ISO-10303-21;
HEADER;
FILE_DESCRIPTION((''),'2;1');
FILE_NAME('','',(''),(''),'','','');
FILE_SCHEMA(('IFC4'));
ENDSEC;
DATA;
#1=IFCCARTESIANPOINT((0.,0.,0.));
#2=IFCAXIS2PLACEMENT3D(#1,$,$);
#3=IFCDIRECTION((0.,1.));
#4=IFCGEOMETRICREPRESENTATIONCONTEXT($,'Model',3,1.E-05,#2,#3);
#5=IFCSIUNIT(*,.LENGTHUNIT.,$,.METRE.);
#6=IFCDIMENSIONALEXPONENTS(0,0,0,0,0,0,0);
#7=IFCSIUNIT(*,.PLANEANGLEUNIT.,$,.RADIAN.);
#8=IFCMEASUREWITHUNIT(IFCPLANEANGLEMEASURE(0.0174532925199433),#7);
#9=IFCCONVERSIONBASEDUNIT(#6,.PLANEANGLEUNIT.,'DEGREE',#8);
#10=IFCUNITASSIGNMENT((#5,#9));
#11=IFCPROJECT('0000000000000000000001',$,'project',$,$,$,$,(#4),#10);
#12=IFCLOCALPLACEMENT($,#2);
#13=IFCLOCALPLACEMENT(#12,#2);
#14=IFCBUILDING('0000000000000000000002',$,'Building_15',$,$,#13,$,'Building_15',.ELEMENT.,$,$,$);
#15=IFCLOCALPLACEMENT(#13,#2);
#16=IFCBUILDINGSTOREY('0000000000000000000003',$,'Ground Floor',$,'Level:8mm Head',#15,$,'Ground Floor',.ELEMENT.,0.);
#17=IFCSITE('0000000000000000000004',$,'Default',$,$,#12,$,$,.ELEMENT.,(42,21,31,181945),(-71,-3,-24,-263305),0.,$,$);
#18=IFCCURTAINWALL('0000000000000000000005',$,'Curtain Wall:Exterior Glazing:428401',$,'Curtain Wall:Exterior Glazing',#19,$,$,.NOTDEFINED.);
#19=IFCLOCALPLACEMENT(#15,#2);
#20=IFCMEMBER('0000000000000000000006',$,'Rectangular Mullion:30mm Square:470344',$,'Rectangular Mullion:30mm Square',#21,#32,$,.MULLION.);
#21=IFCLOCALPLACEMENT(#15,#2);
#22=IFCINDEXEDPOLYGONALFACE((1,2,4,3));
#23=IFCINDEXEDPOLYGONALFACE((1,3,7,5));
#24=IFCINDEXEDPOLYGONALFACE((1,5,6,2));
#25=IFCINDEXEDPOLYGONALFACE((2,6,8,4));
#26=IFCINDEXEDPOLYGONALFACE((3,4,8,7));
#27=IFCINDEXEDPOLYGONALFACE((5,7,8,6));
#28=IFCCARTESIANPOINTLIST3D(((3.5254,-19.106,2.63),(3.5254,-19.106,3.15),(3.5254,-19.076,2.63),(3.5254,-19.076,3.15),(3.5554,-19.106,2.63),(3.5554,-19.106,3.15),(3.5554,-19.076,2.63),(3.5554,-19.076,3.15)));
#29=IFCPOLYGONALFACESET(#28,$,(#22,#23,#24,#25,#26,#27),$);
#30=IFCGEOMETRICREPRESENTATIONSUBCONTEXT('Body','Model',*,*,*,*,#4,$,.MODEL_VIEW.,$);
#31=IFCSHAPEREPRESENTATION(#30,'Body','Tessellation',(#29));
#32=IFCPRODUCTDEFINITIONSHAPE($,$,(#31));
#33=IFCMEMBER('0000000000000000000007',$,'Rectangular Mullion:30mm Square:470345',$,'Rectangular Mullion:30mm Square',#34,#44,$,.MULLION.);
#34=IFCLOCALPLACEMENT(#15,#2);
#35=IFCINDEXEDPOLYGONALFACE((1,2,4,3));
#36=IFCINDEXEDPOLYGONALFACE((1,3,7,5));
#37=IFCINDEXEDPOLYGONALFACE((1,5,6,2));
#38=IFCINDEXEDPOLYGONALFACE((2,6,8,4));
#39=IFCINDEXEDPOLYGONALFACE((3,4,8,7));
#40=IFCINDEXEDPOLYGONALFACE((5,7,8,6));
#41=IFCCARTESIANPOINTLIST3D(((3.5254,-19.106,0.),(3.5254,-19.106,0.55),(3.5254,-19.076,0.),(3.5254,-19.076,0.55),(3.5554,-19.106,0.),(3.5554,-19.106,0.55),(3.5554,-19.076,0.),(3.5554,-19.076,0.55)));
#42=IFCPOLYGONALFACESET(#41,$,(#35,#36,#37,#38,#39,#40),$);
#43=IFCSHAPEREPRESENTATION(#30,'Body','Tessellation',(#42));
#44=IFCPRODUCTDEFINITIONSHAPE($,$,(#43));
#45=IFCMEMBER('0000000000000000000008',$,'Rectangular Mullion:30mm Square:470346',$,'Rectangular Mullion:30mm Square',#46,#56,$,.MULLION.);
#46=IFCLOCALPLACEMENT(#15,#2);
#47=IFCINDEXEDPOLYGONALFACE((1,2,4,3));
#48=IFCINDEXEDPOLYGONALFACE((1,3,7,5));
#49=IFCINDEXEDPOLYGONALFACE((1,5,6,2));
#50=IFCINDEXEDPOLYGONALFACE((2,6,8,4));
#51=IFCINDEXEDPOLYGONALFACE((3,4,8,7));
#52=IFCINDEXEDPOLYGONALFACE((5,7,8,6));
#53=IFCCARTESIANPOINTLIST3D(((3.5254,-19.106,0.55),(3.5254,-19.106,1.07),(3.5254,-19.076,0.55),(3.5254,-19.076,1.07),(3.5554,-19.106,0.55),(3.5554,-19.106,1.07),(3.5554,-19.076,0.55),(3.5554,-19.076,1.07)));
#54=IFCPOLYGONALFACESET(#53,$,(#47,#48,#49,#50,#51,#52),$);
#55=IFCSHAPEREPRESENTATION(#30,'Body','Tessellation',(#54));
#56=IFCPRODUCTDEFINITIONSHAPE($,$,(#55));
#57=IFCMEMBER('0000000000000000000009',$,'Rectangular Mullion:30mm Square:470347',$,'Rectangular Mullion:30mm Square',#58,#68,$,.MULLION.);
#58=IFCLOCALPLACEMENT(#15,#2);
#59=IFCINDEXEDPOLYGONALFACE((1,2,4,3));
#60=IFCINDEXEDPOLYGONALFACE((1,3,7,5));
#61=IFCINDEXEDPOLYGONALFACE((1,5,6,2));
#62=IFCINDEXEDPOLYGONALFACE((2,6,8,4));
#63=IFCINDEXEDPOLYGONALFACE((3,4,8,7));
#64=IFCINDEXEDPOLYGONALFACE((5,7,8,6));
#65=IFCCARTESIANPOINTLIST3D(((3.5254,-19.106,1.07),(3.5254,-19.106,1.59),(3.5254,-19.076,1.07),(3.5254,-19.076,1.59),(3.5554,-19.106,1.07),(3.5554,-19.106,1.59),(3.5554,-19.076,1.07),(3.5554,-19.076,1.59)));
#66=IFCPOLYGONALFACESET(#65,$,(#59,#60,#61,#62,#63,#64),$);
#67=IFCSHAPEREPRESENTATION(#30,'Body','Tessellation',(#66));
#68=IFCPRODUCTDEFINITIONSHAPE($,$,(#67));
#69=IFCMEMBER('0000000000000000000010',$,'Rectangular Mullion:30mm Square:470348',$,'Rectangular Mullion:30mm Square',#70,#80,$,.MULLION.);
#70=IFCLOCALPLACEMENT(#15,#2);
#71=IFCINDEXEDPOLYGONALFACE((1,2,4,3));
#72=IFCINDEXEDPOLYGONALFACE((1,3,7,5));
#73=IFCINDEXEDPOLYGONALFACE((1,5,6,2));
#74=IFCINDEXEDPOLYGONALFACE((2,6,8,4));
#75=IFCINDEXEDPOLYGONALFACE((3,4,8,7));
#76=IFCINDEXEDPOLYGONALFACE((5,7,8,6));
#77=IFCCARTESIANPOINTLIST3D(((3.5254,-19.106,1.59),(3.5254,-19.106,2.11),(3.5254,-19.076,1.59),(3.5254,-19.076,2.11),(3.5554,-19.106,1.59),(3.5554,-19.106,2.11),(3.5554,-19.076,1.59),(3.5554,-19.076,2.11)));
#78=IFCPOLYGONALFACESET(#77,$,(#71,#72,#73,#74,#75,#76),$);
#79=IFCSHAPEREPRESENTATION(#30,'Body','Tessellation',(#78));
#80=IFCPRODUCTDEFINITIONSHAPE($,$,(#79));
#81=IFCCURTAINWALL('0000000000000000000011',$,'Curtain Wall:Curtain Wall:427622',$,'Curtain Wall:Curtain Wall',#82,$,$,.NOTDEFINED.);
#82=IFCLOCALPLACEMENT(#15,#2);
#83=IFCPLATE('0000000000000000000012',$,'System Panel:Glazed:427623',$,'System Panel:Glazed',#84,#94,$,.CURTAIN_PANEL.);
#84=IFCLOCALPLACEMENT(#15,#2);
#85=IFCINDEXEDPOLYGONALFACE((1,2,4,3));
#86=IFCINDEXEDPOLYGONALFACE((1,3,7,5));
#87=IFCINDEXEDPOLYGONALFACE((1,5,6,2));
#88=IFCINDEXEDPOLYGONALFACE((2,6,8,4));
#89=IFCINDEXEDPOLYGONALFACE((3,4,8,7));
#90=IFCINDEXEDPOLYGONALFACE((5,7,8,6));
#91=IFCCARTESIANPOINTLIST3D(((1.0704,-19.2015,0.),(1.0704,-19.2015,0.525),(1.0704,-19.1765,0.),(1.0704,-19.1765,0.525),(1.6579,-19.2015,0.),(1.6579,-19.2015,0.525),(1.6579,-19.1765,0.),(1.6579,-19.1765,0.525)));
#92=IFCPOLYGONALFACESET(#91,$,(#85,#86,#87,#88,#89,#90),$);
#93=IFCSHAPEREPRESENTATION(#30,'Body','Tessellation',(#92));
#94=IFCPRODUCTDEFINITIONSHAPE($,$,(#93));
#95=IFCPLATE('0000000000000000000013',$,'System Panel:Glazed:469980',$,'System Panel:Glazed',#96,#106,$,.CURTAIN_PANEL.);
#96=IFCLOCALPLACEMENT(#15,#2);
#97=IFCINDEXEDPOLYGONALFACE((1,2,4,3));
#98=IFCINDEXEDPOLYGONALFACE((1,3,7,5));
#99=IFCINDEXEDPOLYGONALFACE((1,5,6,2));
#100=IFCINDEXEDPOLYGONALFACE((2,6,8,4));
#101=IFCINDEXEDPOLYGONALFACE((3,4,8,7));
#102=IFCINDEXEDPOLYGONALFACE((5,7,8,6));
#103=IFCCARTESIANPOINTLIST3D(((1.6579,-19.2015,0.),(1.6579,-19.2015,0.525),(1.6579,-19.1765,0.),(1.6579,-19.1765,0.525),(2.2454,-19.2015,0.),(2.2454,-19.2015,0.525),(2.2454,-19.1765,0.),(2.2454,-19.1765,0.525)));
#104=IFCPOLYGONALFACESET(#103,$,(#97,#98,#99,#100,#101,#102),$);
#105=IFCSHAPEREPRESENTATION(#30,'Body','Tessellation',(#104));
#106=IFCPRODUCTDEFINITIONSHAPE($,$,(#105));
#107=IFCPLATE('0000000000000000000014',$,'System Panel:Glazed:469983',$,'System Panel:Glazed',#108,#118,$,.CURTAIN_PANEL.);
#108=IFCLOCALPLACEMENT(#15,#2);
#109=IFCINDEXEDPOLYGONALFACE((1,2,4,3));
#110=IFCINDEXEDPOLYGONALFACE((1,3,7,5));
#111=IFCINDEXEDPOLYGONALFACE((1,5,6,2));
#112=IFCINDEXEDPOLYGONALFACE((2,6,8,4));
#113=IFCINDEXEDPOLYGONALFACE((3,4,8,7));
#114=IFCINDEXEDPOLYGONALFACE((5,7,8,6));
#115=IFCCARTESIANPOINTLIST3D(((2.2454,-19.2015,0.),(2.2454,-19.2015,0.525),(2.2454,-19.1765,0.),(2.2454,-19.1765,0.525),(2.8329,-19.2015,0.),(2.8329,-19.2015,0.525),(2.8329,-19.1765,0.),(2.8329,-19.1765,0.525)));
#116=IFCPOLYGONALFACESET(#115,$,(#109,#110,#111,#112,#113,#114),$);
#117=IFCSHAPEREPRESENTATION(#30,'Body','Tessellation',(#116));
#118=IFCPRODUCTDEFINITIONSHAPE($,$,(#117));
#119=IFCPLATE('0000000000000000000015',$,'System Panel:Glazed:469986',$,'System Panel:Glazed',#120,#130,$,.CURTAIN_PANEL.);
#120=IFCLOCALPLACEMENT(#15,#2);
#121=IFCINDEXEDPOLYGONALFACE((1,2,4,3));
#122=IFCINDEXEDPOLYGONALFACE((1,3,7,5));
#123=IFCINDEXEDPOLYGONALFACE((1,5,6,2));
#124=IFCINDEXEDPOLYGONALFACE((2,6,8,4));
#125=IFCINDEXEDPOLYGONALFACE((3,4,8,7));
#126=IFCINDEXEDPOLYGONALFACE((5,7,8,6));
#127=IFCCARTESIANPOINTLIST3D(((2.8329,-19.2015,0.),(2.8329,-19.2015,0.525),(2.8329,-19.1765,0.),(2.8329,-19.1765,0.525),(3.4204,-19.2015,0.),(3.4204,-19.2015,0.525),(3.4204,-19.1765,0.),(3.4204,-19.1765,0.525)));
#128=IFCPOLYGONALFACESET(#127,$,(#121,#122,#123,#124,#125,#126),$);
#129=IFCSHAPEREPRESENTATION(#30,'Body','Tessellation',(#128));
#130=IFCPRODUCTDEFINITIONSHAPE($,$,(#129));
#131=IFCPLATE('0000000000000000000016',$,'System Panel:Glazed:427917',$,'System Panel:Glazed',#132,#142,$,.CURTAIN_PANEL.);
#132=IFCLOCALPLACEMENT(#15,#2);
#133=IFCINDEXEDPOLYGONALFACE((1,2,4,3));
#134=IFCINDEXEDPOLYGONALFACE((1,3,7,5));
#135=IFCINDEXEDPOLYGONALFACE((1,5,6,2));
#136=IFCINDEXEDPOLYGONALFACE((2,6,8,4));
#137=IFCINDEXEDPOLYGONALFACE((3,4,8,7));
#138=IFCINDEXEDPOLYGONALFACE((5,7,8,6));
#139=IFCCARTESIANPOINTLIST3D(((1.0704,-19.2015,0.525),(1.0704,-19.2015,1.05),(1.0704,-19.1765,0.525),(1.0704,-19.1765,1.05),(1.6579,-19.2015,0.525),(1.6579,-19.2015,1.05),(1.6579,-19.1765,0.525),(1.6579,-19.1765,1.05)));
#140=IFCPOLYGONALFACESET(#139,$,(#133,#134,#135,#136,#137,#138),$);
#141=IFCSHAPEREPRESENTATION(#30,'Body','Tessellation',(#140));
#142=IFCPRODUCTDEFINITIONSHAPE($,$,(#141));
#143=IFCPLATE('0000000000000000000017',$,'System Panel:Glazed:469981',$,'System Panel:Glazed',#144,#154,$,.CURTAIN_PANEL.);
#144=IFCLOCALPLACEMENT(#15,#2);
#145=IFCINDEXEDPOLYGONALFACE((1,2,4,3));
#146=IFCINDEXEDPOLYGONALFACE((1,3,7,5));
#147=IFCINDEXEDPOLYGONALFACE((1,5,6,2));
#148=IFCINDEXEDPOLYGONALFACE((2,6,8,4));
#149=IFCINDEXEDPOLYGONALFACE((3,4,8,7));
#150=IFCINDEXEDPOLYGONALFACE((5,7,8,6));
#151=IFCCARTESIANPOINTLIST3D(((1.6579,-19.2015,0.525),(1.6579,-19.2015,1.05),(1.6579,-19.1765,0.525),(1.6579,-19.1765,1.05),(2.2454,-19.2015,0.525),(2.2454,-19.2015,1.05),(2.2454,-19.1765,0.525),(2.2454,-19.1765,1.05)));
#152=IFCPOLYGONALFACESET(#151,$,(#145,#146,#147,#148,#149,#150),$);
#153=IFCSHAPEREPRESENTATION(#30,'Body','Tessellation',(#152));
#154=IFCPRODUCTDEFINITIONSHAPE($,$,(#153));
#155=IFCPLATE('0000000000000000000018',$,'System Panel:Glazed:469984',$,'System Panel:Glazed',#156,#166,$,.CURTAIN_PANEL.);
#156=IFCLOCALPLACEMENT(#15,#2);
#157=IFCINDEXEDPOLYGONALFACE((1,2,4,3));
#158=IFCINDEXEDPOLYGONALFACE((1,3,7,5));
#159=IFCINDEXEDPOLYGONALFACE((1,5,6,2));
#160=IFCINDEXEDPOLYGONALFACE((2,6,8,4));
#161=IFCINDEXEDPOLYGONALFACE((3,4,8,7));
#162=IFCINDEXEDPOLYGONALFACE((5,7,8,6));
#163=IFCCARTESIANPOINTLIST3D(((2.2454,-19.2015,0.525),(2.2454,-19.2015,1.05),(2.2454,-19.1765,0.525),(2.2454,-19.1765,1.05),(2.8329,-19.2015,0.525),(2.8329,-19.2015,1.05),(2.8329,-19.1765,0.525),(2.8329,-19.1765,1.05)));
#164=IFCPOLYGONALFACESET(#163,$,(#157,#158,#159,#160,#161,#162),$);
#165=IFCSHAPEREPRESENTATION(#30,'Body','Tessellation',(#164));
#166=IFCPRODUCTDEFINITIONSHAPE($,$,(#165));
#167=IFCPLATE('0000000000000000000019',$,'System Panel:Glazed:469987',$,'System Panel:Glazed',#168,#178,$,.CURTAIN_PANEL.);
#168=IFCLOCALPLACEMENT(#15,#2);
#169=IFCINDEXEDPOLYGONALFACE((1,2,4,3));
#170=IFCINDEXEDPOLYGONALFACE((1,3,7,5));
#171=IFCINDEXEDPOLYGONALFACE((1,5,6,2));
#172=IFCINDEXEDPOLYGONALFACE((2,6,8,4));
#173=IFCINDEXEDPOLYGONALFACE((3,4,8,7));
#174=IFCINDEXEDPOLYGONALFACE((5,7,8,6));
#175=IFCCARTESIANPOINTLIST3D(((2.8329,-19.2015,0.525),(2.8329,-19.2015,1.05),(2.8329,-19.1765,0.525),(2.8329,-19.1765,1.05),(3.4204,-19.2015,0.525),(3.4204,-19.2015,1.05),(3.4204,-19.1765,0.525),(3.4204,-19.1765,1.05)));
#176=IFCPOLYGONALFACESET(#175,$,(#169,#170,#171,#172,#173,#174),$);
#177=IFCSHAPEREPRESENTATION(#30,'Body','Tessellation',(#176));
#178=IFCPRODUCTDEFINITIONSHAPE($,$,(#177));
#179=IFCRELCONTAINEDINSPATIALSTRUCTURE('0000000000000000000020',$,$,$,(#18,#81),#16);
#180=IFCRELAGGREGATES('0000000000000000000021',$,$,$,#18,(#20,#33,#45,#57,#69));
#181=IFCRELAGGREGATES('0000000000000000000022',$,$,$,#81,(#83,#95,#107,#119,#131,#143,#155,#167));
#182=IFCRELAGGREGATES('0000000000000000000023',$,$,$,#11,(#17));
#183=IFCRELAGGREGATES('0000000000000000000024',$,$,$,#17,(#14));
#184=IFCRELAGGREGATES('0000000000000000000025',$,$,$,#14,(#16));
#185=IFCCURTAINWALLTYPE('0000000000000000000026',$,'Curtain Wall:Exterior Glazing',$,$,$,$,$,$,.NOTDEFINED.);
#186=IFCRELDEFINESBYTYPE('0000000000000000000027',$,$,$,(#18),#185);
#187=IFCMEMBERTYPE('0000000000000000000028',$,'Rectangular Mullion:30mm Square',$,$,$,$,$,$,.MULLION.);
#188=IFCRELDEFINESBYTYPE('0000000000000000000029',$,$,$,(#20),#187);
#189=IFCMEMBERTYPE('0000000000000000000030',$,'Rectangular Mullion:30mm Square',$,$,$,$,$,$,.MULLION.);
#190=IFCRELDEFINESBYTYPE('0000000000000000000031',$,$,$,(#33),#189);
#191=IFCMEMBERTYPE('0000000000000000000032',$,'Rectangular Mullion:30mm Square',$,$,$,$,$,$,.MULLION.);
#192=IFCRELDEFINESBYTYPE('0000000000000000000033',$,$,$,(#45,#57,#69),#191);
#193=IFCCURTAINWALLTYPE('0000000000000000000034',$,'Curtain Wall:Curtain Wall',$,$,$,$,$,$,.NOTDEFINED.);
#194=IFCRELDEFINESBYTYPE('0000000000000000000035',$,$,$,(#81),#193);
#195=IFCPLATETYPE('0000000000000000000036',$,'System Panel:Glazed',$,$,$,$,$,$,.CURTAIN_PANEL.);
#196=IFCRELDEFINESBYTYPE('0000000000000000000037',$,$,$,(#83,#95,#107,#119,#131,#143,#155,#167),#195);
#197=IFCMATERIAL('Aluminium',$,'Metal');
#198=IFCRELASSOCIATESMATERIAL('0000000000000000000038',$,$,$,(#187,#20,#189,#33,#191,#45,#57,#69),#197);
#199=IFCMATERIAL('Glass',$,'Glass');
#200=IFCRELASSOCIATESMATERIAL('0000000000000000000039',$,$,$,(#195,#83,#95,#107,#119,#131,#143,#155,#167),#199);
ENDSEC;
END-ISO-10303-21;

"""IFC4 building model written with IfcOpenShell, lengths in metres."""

from ifc_helpers import new_model, entity, si_unit, converted_unit, direction, frame, origin, place, context, subcontext, project, spatial, indexed_curve, outline, extrude, source, transform, mapped, material, type_object, type_shapes, element, aggregate, save


model = new_model("IFC4")

# Units and contexts
model_context = context("Model", 3, precision=1e-05, world=origin(), true_north=direction((0.0, 1.0)))
body_context = subcontext(model_context, "Body", "Model", "MODEL_VIEW")
ifc_project = project(units=[si_unit("LENGTHUNIT", "METRE"), converted_unit("PLANEANGLEUNIT", "DEGREE", entity("IfcPlaneAngleMeasure", 0.0174532925199433), si_unit("PLANEANGLEUNIT", "RADIAN"), dimensions=[0, 0, 0, 0, 0, 0, 0])], contexts=[model_context])

# Site, building, storey
site_placement = place(None, origin())
site = spatial("IfcSite", under=ifc_project, at=site_placement, Name="Default", CompositionType="ELEMENT", RefLatitude=(42, 21, 31, 181945), RefLongitude=(-71, -3, -24, -263305), RefElevation=0.0)
building_placement = place(site_placement, origin())
building = spatial("IfcBuilding", under=site, at=building_placement, Name="Building_15", LongName="Building_15", CompositionType="ELEMENT")
storey_placement = place(building_placement, origin())
storey = spatial("IfcBuildingStorey", under=building, at=storey_placement, Name="Ground Floor", ObjectType="Level:8mm Head", LongName="Ground Floor", CompositionType="ELEMENT", Elevation=0.0)

# Curtain wall, members
curtain_wall_type_1 = type_object("IfcCurtainWallType", Name="Curtain Wall:Exterior Glazing", PredefinedType="NOTDEFINED")
curtain_wall_1_placement = place(storey_placement, origin())
curtain_wall_1 = element("IfcCurtainWall", 1, at=curtain_wall_1_placement, inside=storey, type_object=curtain_wall_type_1, Name="Curtain Wall:Exterior Glazing:428401", ObjectType="Curtain Wall:Exterior Glazing", PredefinedType="NOTDEFINED")
ifc_material_1 = material(Name="Aluminium", Category="Metal")
member_type_1 = type_object("IfcMemberType", Name="Rectangular Mullion:30mm Square", PredefinedType="MULLION", material=ifc_material_1)
shared_shape_1 = source(origin(), body_context, "Body", "SweptSolid", [
    extrude(outline(indexed_curve([(-0.015, -0.015), (0.015, -0.015), (0.015, 0.015), (-0.015, 0.015), (-0.015, -0.015)], self_intersect=False)), frame((-0.015, 0.0, -0.52), z_axis=(0.0, 0.0, 1.0), x_axis=(-1.0, 0.0, 0.0)), (0.0, 0.0, 1.0), 0.52),
])
type_shapes(member_type_1, [shared_shape_1])
member_1_placement = place(curtain_wall_1_placement, frame((3.5404, -19.106, 3.15), z_axis=(0.0, 0.0, 1.0), x_axis=(0.0, -1.0, 0.0)))
member_1 = element("IfcMember", 2, at=member_1_placement, type_object=member_type_1, material=ifc_material_1, Name="Rectangular Mullion:30mm Square:470344", ObjectType="Rectangular Mullion:30mm Square", PredefinedType="MULLION", context=body_context, shape_type="MappedRepresentation", body=[
    mapped(shared_shape_1, transform((0.0, 0.0, 0.0), scale=1.0)),
])
member_type_2 = type_object("IfcMemberType", Name="Rectangular Mullion:30mm Square", PredefinedType="MULLION", material=ifc_material_1)
shared_shape_2 = source(origin(), body_context, "Body", "SweptSolid", [
    extrude(outline(indexed_curve([(-0.015, -0.015), (0.015, -0.015), (0.015, 0.015), (-0.015, 0.015), (-0.015, -0.015)], self_intersect=False)), frame((-0.015, 0.0, -0.55), z_axis=(0.0, 0.0, 1.0), x_axis=(-1.0, 0.0, 0.0)), (0.0, 0.0, 1.0), 0.55),
])
type_shapes(member_type_2, [shared_shape_2])
member_2_placement = place(curtain_wall_1_placement, frame((3.5404, -19.106, 0.55), z_axis=(0.0, 0.0, 1.0), x_axis=(0.0, -1.0, 0.0)))
member_2 = element("IfcMember", 3, at=member_2_placement, type_object=member_type_2, material=ifc_material_1, Name="Rectangular Mullion:30mm Square:470345", ObjectType="Rectangular Mullion:30mm Square", PredefinedType="MULLION", context=body_context, shape_type="MappedRepresentation", body=[
    mapped(shared_shape_2, transform((0.0, 0.0, 0.0), scale=1.0)),
])
member_type_3 = type_object("IfcMemberType", Name="Rectangular Mullion:30mm Square", PredefinedType="MULLION", material=ifc_material_1)
shared_shape_3 = source(origin(), body_context, "Body", "SweptSolid", [
    extrude(outline(indexed_curve([(-0.015, -0.015), (0.015, -0.015), (0.015, 0.015), (-0.015, 0.015), (-0.015, -0.015)], self_intersect=False)), frame((-0.015, 0.0, -0.52), z_axis=(0.0, 0.0, 1.0), x_axis=(-1.0, 0.0, 0.0)), (0.0, 0.0, 1.0), 0.52),
])
type_shapes(member_type_3, [shared_shape_3])
member_3_placement = place(curtain_wall_1_placement, frame((3.5404, -19.106, 1.07), z_axis=(0.0, 0.0, 1.0), x_axis=(0.0, -1.0, 0.0)))
member_3 = element("IfcMember", 4, at=member_3_placement, type_object=member_type_3, material=ifc_material_1, Name="Rectangular Mullion:30mm Square:470346", ObjectType="Rectangular Mullion:30mm Square", PredefinedType="MULLION", context=body_context, shape_type="MappedRepresentation", body=[
    mapped(shared_shape_3, transform((0.0, 0.0, 0.0), scale=1.0)),
])
member_4_placement = place(curtain_wall_1_placement, frame((3.5404, -19.106, 1.59), z_axis=(0.0, 0.0, 1.0), x_axis=(0.0, -1.0, 0.0)))
member_4 = element("IfcMember", 5, at=member_4_placement, type_object=member_type_3, material=ifc_material_1, Name="Rectangular Mullion:30mm Square:470347", ObjectType="Rectangular Mullion:30mm Square", PredefinedType="MULLION", context=body_context, shape_type="MappedRepresentation", body=[
    mapped(shared_shape_3, transform((0.0, 0.0, 0.0), scale=1.0)),
])
member_5_placement = place(curtain_wall_1_placement, frame((3.5404, -19.106, 2.11), z_axis=(0.0, 0.0, 1.0), x_axis=(0.0, -1.0, 0.0)))
member_5 = element("IfcMember", 6, at=member_5_placement, type_object=member_type_3, material=ifc_material_1, Name="Rectangular Mullion:30mm Square:470348", ObjectType="Rectangular Mullion:30mm Square", PredefinedType="MULLION", context=body_context, shape_type="MappedRepresentation", body=[
    mapped(shared_shape_3, transform((0.0, 0.0, 0.0), scale=1.0)),
])
aggregate(curtain_wall_1, [member_1, member_2, member_3, member_4, member_5])

# Curtain wall, plates
curtain_wall_type_2 = type_object("IfcCurtainWallType", Name="Curtain Wall:Curtain Wall", PredefinedType="NOTDEFINED")
curtain_wall_2_placement = place(storey_placement, origin())
curtain_wall_2 = element("IfcCurtainWall", 7, at=curtain_wall_2_placement, inside=storey, type_object=curtain_wall_type_2, Name="Curtain Wall:Curtain Wall:427622", ObjectType="Curtain Wall:Curtain Wall", PredefinedType="NOTDEFINED")
ifc_material_2 = material(Name="Glass", Category="Glass")
plate_type = type_object("IfcPlateType", Name="System Panel:Glazed", PredefinedType="CURTAIN_PANEL", material=ifc_material_2)
shared_shape_4 = source(origin(), body_context, "Body", "SweptSolid", [
    extrude(outline(indexed_curve([(-0.0125, -0.2938), (0.0125, -0.2938), (0.0125, 0.2938), (-0.0125, 0.2938), (-0.0125, -0.2938)], self_intersect=False)), frame((0.0, 0.037, 0.0), z_axis=(0.0, 0.0, 1.0), x_axis=(0.0, 1.0, 0.0)), (0.0, 0.0, 1.0), 0.525),
])
type_shapes(plate_type, [shared_shape_4])
plate_1_placement = place(curtain_wall_2_placement, frame((1.3641, -19.226, 0.0)))
plate_1 = element("IfcPlate", 8, at=plate_1_placement, type_object=plate_type, material=ifc_material_2, Name="System Panel:Glazed:427623", ObjectType="System Panel:Glazed", PredefinedType="CURTAIN_PANEL", context=body_context, shape_type="MappedRepresentation", body=[
    mapped(shared_shape_4, transform((0.0, 0.0, 0.0), scale=1.0)),
])
plate_2_placement = place(curtain_wall_2_placement, frame((1.9516, -19.226, 0.0)))
plate_2 = element("IfcPlate", 9, at=plate_2_placement, type_object=plate_type, material=ifc_material_2, Name="System Panel:Glazed:469980", ObjectType="System Panel:Glazed", PredefinedType="CURTAIN_PANEL", context=body_context, shape_type="MappedRepresentation", body=[
    mapped(shared_shape_4, transform((0.0, 0.0, 0.0), scale=1.0)),
])
plate_3_placement = place(curtain_wall_2_placement, frame((2.5391, -19.226, 0.0)))
plate_3 = element("IfcPlate", 10, at=plate_3_placement, type_object=plate_type, material=ifc_material_2, Name="System Panel:Glazed:469983", ObjectType="System Panel:Glazed", PredefinedType="CURTAIN_PANEL", context=body_context, shape_type="MappedRepresentation", body=[
    mapped(shared_shape_4, transform((0.0, 0.0, 0.0), scale=1.0)),
])
plate_4_placement = place(curtain_wall_2_placement, frame((3.1266, -19.226, 0.0)))
plate_4 = element("IfcPlate", 11, at=plate_4_placement, type_object=plate_type, material=ifc_material_2, Name="System Panel:Glazed:469986", ObjectType="System Panel:Glazed", PredefinedType="CURTAIN_PANEL", context=body_context, shape_type="MappedRepresentation", body=[
    mapped(shared_shape_4, transform((0.0, 0.0, 0.0), scale=1.0)),
])
plate_5_placement = place(curtain_wall_2_placement, frame((1.3641, -19.226, 0.525)))
plate_5 = element("IfcPlate", 12, at=plate_5_placement, type_object=plate_type, material=ifc_material_2, Name="System Panel:Glazed:427917", ObjectType="System Panel:Glazed", PredefinedType="CURTAIN_PANEL", context=body_context, shape_type="MappedRepresentation", body=[
    mapped(shared_shape_4, transform((0.0, 0.0, 0.0), scale=1.0)),
])
plate_6_placement = place(curtain_wall_2_placement, frame((1.9516, -19.226, 0.525)))
plate_6 = element("IfcPlate", 13, at=plate_6_placement, type_object=plate_type, material=ifc_material_2, Name="System Panel:Glazed:469981", ObjectType="System Panel:Glazed", PredefinedType="CURTAIN_PANEL", context=body_context, shape_type="MappedRepresentation", body=[
    mapped(shared_shape_4, transform((0.0, 0.0, 0.0), scale=1.0)),
])
plate_7_placement = place(curtain_wall_2_placement, frame((2.5391, -19.226, 0.525)))
plate_7 = element("IfcPlate", 14, at=plate_7_placement, type_object=plate_type, material=ifc_material_2, Name="System Panel:Glazed:469984", ObjectType="System Panel:Glazed", PredefinedType="CURTAIN_PANEL", context=body_context, shape_type="MappedRepresentation", body=[
    mapped(shared_shape_4, transform((0.0, 0.0, 0.0), scale=1.0)),
])
plate_8_placement = place(curtain_wall_2_placement, frame((3.1266, -19.226, 0.525)))
plate_8 = element("IfcPlate", 15, at=plate_8_placement, type_object=plate_type, material=ifc_material_2, Name="System Panel:Glazed:469987", ObjectType="System Panel:Glazed", PredefinedType="CURTAIN_PANEL", context=body_context, shape_type="MappedRepresentation", body=[
    mapped(shared_shape_4, transform((0.0, 0.0, 0.0), scale=1.0)),
])
aggregate(curtain_wall_2, [plate_1, plate_2, plate_3, plate_4, plate_5, plate_6, plate_7, plate_8])

save(model, "model.ifc")
